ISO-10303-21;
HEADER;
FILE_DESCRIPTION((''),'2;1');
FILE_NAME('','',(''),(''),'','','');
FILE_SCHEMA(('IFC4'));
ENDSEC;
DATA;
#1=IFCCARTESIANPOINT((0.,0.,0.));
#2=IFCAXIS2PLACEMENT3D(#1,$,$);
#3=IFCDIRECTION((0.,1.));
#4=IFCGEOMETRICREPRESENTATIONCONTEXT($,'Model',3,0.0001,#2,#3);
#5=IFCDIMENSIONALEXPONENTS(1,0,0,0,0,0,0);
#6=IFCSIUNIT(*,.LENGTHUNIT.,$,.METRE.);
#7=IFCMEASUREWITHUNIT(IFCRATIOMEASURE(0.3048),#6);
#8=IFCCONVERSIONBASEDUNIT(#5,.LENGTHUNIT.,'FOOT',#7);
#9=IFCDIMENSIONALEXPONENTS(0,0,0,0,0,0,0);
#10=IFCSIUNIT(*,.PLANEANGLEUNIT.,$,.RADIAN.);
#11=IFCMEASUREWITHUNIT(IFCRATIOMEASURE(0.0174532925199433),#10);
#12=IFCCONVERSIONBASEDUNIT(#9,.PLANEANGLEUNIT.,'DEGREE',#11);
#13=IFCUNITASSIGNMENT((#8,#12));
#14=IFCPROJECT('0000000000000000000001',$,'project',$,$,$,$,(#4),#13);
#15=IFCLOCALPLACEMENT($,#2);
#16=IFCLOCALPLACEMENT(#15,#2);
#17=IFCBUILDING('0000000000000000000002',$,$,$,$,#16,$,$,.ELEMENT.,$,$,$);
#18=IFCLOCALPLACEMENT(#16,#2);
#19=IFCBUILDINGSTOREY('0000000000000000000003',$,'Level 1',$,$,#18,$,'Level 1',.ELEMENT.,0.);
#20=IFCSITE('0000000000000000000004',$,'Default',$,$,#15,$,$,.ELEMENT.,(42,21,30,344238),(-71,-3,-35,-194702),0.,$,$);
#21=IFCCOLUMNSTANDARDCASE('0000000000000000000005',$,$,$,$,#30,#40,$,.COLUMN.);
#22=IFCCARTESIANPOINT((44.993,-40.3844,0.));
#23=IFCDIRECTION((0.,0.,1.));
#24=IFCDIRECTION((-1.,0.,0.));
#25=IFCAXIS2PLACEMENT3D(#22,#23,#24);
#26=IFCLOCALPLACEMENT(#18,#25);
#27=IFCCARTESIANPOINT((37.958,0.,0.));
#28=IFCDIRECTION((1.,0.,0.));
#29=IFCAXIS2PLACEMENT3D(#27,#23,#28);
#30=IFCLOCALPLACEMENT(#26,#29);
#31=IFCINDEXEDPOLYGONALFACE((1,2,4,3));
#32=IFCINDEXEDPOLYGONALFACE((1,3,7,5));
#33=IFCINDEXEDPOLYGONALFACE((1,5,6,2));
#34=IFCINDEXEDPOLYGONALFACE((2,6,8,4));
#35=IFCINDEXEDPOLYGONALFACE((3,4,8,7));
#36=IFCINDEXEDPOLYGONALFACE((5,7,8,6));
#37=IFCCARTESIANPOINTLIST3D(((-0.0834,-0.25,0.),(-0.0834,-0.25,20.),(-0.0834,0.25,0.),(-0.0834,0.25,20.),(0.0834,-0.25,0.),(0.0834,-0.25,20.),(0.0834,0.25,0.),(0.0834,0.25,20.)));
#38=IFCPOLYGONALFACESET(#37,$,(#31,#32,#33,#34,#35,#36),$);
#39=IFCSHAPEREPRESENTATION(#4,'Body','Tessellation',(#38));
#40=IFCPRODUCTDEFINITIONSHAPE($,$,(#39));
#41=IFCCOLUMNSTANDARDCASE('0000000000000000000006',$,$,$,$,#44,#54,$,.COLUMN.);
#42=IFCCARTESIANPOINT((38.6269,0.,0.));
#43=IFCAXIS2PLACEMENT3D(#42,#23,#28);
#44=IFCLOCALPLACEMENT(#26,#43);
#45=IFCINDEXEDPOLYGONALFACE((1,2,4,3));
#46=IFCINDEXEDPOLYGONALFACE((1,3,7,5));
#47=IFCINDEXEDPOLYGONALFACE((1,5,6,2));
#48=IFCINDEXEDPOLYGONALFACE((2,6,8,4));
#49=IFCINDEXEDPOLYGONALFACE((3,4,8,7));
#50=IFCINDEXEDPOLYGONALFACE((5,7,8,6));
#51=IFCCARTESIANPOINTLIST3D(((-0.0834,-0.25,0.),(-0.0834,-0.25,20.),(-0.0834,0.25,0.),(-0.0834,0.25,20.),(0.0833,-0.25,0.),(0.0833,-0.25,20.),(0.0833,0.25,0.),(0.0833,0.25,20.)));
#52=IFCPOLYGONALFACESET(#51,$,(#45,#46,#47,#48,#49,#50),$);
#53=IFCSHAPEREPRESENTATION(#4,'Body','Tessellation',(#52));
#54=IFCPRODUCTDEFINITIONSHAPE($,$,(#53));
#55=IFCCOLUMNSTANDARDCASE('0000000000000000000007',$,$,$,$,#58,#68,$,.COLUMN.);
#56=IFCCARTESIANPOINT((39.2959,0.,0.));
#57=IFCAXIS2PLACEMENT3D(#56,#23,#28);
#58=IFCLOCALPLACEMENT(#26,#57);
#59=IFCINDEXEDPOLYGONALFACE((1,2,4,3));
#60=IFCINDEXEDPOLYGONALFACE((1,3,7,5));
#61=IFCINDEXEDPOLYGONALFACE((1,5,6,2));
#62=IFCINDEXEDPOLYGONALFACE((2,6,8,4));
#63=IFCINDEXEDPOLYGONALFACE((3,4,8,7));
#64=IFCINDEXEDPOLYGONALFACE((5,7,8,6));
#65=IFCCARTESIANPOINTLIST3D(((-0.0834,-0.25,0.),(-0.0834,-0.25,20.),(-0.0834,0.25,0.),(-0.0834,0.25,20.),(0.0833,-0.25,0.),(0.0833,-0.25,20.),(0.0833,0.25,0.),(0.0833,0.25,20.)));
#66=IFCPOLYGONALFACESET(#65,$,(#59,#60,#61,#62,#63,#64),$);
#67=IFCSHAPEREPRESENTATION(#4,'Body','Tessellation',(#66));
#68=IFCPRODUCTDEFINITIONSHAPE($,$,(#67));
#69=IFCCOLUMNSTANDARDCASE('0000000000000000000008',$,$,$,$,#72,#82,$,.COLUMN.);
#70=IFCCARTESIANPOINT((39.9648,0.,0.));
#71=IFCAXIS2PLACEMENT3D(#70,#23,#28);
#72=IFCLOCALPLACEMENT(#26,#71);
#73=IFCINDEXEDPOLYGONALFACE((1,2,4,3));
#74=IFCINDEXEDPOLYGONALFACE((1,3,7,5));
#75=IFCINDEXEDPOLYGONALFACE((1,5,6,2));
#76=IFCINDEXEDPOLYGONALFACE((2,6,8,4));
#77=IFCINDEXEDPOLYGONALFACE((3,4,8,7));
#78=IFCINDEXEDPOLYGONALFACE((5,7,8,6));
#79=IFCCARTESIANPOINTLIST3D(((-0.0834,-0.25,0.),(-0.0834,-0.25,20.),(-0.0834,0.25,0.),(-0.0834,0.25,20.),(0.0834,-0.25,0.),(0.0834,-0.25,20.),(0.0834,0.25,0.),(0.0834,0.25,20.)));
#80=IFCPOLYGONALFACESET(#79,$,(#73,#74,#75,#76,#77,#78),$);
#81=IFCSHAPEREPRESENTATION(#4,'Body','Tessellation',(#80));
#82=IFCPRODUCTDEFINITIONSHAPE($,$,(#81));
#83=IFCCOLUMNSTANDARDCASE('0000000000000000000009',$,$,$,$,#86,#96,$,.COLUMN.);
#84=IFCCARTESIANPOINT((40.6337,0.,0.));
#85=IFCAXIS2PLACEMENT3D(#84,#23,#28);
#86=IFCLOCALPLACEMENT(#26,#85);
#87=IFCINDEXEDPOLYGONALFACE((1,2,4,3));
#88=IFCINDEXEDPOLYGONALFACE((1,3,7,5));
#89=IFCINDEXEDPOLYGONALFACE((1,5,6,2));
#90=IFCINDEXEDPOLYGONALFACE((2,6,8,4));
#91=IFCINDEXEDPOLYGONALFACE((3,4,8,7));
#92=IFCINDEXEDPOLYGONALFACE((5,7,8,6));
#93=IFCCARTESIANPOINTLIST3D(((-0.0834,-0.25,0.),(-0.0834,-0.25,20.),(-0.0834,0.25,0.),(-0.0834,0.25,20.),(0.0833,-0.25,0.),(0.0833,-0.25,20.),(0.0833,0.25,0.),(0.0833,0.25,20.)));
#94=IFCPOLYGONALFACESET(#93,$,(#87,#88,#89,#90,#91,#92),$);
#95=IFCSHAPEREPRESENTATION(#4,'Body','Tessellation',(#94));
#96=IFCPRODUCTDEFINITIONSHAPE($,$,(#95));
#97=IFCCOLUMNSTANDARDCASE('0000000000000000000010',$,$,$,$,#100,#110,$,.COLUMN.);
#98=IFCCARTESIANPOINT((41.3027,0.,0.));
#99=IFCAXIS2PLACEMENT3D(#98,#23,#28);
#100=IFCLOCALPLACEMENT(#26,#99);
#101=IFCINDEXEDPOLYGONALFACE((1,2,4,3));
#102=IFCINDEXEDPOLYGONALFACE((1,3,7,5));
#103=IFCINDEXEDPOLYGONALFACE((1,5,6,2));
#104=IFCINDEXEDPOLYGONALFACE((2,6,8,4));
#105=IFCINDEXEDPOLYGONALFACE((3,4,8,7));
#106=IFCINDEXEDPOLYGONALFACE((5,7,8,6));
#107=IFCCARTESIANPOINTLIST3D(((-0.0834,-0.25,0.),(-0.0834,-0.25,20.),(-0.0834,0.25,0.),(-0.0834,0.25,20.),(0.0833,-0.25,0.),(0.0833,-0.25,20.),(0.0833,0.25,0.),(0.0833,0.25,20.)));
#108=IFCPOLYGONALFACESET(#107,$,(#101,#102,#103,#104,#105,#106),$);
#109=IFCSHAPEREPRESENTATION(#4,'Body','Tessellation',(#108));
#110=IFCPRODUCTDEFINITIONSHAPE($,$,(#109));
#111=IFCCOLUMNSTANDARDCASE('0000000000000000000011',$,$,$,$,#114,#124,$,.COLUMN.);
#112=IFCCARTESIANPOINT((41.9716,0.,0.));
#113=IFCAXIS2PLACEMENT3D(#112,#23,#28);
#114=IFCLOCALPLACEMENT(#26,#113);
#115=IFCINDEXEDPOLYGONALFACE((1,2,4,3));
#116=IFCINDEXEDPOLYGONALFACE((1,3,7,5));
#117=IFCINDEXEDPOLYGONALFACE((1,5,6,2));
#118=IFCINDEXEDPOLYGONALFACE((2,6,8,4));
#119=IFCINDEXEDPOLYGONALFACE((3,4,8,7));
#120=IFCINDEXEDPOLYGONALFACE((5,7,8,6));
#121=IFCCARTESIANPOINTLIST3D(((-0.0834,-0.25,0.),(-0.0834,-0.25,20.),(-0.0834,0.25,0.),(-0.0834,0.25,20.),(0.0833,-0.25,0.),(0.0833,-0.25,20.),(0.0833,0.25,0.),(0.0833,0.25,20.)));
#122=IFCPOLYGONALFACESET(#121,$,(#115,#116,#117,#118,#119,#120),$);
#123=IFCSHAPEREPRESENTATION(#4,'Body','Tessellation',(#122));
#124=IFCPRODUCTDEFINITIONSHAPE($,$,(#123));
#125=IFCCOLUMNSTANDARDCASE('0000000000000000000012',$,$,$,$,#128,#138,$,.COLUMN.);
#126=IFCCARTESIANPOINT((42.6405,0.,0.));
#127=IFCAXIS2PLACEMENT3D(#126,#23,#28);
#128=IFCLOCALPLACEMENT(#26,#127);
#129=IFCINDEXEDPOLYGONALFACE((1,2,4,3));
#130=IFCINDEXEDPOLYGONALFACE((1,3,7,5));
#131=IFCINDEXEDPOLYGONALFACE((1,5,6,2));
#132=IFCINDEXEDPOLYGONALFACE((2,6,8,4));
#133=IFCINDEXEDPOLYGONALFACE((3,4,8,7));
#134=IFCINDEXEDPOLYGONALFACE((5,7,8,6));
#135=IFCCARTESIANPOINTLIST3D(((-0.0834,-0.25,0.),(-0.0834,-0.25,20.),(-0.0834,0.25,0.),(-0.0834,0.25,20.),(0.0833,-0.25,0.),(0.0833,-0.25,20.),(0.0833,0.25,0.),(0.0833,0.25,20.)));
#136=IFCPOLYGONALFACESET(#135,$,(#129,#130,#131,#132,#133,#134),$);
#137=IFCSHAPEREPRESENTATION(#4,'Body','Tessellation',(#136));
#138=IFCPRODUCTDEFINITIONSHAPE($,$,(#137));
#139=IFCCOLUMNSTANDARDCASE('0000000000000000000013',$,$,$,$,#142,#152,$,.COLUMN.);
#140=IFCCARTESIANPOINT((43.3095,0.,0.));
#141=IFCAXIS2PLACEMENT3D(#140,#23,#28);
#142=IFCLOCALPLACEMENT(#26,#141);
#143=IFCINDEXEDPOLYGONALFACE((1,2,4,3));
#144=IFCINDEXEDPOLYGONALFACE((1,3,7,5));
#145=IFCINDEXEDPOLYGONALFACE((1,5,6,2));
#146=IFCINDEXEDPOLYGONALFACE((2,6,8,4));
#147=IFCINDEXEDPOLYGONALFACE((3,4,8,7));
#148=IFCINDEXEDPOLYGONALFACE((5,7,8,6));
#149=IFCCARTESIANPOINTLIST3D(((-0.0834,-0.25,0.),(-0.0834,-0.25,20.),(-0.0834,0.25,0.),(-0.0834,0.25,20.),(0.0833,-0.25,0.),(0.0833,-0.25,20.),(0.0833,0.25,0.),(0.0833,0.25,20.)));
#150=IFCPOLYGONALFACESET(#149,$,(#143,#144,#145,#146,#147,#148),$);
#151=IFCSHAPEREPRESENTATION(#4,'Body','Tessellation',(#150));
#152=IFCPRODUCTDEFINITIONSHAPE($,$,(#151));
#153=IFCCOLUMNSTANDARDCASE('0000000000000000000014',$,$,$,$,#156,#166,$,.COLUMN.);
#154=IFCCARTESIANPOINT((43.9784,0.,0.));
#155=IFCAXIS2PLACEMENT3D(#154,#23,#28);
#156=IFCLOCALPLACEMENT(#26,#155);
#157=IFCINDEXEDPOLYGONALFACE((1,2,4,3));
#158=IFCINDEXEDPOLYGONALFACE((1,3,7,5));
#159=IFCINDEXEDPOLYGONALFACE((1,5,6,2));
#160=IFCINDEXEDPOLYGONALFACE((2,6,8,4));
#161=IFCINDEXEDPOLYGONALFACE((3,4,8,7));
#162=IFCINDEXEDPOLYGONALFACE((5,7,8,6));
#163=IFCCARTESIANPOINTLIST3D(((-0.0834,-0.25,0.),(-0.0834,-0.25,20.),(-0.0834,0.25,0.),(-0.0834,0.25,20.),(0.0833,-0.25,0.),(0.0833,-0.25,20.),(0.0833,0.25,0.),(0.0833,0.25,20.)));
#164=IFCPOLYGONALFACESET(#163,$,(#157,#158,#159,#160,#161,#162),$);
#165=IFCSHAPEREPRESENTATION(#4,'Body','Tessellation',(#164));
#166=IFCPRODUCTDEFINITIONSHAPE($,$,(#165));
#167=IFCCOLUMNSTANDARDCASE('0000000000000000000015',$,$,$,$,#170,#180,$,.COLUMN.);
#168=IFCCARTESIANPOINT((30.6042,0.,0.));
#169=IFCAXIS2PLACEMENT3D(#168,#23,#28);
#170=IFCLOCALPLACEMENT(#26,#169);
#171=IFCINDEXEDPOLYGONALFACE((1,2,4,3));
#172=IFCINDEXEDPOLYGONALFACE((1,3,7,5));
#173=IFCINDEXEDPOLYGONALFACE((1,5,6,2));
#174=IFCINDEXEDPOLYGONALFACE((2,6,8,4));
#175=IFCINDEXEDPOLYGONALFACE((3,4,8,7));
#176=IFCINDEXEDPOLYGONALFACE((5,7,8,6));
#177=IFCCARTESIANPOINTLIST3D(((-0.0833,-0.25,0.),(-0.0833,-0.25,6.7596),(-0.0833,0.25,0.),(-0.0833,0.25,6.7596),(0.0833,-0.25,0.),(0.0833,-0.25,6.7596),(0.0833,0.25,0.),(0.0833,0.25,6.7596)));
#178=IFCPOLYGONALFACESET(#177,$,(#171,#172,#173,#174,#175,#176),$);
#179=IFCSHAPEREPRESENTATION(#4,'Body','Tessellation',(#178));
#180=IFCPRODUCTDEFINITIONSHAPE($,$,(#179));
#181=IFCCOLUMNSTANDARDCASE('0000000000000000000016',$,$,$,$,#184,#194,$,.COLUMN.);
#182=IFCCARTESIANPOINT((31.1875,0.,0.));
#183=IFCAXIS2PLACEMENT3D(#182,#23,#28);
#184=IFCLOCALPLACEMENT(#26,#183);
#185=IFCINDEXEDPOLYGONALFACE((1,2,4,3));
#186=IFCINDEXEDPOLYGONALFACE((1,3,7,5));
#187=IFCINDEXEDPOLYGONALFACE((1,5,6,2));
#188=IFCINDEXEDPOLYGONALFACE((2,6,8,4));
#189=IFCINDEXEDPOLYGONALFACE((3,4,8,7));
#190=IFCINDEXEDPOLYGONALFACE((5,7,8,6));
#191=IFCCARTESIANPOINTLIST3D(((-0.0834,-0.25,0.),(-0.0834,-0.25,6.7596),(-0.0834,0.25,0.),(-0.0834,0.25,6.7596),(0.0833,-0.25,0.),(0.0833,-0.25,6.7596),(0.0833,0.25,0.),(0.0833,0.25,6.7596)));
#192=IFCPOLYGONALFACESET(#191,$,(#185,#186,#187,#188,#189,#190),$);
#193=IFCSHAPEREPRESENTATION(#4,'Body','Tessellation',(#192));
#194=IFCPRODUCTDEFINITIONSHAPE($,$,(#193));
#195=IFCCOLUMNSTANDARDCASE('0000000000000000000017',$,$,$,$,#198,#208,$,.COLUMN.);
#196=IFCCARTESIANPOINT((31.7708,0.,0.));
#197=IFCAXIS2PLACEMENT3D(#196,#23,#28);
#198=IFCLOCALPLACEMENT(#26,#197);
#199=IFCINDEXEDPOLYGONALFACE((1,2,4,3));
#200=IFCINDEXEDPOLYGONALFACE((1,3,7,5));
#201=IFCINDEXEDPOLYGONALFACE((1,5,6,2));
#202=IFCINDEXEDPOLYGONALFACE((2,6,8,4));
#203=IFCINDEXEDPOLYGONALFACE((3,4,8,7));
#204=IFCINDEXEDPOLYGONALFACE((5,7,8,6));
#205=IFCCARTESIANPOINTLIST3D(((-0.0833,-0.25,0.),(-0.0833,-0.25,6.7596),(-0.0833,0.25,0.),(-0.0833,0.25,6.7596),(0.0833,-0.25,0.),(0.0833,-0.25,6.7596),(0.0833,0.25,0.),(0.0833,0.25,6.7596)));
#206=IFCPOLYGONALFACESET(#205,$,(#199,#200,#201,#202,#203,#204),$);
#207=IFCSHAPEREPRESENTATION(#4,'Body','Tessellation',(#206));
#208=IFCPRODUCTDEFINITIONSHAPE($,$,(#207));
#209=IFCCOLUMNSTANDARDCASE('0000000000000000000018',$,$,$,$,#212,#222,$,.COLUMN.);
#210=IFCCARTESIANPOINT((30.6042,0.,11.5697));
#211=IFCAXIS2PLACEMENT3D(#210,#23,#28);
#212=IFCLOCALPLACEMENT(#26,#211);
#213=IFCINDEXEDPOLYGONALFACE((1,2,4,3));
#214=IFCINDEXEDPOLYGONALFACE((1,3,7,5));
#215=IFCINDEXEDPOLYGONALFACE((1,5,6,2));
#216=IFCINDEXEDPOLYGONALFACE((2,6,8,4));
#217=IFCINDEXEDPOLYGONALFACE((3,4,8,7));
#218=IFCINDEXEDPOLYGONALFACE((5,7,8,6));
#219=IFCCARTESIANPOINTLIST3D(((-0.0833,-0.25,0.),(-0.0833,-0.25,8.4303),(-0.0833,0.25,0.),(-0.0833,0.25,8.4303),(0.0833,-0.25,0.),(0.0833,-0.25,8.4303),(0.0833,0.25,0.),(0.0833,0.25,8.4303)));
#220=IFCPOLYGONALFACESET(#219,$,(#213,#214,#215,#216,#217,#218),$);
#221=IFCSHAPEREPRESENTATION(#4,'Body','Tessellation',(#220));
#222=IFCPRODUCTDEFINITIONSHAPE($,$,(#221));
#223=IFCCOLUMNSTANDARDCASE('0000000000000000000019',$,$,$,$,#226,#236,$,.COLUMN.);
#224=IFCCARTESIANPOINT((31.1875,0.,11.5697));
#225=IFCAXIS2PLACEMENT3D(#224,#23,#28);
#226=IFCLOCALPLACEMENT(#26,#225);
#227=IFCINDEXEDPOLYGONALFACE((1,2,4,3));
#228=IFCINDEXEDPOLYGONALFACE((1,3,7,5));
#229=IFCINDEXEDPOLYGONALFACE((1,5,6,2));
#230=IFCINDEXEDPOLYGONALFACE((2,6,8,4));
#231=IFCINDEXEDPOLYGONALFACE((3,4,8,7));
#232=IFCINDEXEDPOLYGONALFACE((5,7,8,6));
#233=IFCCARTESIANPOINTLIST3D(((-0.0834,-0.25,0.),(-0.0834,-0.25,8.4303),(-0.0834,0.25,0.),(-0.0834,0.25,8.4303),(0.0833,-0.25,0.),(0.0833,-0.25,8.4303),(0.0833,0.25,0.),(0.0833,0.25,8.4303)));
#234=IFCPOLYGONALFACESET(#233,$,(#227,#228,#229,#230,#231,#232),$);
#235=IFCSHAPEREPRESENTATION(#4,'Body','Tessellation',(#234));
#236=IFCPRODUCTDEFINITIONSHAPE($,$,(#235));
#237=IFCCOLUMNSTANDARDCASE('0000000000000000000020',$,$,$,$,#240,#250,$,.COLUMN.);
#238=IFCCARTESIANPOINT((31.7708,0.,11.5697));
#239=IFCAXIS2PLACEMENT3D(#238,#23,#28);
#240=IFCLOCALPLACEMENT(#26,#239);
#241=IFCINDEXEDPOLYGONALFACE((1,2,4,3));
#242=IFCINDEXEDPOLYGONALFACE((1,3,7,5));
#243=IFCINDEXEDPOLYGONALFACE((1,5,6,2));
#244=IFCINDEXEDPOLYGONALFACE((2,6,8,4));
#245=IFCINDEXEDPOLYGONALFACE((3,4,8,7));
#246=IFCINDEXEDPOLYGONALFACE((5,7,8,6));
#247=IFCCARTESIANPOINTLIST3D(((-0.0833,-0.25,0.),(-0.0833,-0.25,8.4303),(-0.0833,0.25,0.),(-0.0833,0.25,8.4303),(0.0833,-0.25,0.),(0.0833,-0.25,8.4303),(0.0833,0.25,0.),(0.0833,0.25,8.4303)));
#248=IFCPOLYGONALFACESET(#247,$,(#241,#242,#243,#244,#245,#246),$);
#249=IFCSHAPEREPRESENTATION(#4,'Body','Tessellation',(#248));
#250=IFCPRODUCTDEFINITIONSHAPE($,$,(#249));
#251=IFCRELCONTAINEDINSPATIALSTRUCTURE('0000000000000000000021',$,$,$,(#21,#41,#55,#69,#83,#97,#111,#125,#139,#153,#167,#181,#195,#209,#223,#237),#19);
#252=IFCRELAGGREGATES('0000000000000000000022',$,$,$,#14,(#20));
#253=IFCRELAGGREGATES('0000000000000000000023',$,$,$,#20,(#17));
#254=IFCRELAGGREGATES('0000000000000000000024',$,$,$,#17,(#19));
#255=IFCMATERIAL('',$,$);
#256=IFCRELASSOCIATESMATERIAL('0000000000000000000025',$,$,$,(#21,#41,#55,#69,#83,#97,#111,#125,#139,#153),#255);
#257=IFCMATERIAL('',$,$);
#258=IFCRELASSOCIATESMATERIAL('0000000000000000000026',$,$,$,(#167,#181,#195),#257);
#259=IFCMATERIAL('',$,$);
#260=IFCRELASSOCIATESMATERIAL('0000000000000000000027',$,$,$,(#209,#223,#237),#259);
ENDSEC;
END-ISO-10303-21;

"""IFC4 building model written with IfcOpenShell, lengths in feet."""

from ifc_helpers import new_model, entity, si_unit, converted_unit, direction, frame, origin, place, context, project, spatial, rectangle, extrude, material, element, save


model = new_model("IFC4")

# Units and contexts
model_context = context("Model", 3, precision=0.0001, world=origin(), true_north=direction((0.0, 1.0)))
ifc_project = project(units=[converted_unit("LENGTHUNIT", "FOOT", entity("IfcRatioMeasure", 0.3048), si_unit("LENGTHUNIT", "METRE"), dimensions=[1, 0, 0, 0, 0, 0, 0]), converted_unit("PLANEANGLEUNIT", "DEGREE", entity("IfcRatioMeasure", 0.0174532925199433), si_unit("PLANEANGLEUNIT", "RADIAN"), dimensions=[0, 0, 0, 0, 0, 0, 0])], contexts=[model_context])

# Site, building, storey
site_placement = place(None, origin())
site = spatial("IfcSite", under=ifc_project, at=site_placement, Name="Default", CompositionType="ELEMENT", RefLatitude=(42, 21, 30, 344238), RefLongitude=(-71, -3, -35, -194702), RefElevation=0.0)
building_placement = place(site_placement, origin())
building = spatial("IfcBuilding", under=site, at=building_placement, CompositionType="ELEMENT")
storey_placement = place(building_placement, origin())
storey = spatial("IfcBuildingStorey", under=building, at=storey_placement, Name="Level 1", LongName="Level 1", CompositionType="ELEMENT", Elevation=0.0)

# Columns
placement = place(storey_placement, frame((44.993, -40.3844, 0.0), z_axis=(0.0, 0.0, 1.0), x_axis=(-1.0, 0.0, 0.0)))
ifc_material_1 = material(Name="")
for number, where, z_axis, x_axis in (
    (1, (37.958, 0.0, 0.0), (0.0, 0.0, 1.0), (1.0, 0.0, 0.0)),
    (2, (38.6269, 0.0, 0.0), (0.0, 0.0, 1.0), (1.0, 0.0, 0.0)),
    (3, (39.2959, 0.0, 0.0), (0.0, 0.0, 1.0), (1.0, 0.0, 0.0)),
    (4, (39.9648, 0.0, 0.0), (0.0, 0.0, 1.0), (1.0, 0.0, 0.0)),
    (5, (40.6337, 0.0, 0.0), (0.0, 0.0, 1.0), (1.0, 0.0, 0.0)),
    (6, (41.3027, 0.0, 0.0), (0.0, 0.0, 1.0), (1.0, 0.0, 0.0)),
    (7, (41.9716, 0.0, 0.0), (0.0, 0.0, 1.0), (1.0, 0.0, 0.0)),
    (8, (42.6405, 0.0, 0.0), (0.0, 0.0, 1.0), (1.0, 0.0, 0.0)),
    (9, (43.3095, 0.0, 0.0), (0.0, 0.0, 1.0), (1.0, 0.0, 0.0)),
    (10, (43.9784, 0.0, 0.0), (0.0, 0.0, 1.0), (1.0, 0.0, 0.0)),
):
    element("IfcColumnStandardCase", number, at=place(placement, frame(where, z_axis=z_axis, x_axis=x_axis)), inside=storey, material=ifc_material_1, PredefinedType="COLUMN", context=model_context, shape_type="SweptSolid", body=[
        extrude(rectangle(XDim=0.1667, YDim=0.5), origin(), (0.0, 0.0, 1.0), 20.0),
    ])
ifc_material_2 = material(Name="")
for number, where, z_axis, x_axis in (
    (11, (30.6042, 0.0, 0.0), (0.0, 0.0, 1.0), (1.0, 0.0, 0.0)),
    (12, (31.1875, 0.0, 0.0), (0.0, 0.0, 1.0), (1.0, 0.0, 0.0)),
    (13, (31.7708, 0.0, 0.0), (0.0, 0.0, 1.0), (1.0, 0.0, 0.0)),
):
    element("IfcColumnStandardCase", number, at=place(placement, frame(where, z_axis=z_axis, x_axis=x_axis)), inside=storey, material=ifc_material_2, PredefinedType="COLUMN", context=model_context, shape_type="SweptSolid", body=[
        extrude(rectangle(XDim=0.1667, YDim=0.5), origin(), (0.0, 0.0, 1.0), 6.7596),
    ])
ifc_material_3 = material(Name="")
for number, where, z_axis, x_axis in (
    (14, (30.6042, 0.0, 11.5697), (0.0, 0.0, 1.0), (1.0, 0.0, 0.0)),
    (15, (31.1875, 0.0, 11.5697), (0.0, 0.0, 1.0), (1.0, 0.0, 0.0)),
    (16, (31.7708, 0.0, 11.5697), (0.0, 0.0, 1.0), (1.0, 0.0, 0.0)),
):
    element("IfcColumnStandardCase", number, at=place(placement, frame(where, z_axis=z_axis, x_axis=x_axis)), inside=storey, material=ifc_material_3, PredefinedType="COLUMN", context=model_context, shape_type="SweptSolid", body=[
        extrude(rectangle(XDim=0.1667, YDim=0.5), origin(), (0.0, 0.0, 1.0), 8.4303),
    ])

save(model, "model.ifc")
